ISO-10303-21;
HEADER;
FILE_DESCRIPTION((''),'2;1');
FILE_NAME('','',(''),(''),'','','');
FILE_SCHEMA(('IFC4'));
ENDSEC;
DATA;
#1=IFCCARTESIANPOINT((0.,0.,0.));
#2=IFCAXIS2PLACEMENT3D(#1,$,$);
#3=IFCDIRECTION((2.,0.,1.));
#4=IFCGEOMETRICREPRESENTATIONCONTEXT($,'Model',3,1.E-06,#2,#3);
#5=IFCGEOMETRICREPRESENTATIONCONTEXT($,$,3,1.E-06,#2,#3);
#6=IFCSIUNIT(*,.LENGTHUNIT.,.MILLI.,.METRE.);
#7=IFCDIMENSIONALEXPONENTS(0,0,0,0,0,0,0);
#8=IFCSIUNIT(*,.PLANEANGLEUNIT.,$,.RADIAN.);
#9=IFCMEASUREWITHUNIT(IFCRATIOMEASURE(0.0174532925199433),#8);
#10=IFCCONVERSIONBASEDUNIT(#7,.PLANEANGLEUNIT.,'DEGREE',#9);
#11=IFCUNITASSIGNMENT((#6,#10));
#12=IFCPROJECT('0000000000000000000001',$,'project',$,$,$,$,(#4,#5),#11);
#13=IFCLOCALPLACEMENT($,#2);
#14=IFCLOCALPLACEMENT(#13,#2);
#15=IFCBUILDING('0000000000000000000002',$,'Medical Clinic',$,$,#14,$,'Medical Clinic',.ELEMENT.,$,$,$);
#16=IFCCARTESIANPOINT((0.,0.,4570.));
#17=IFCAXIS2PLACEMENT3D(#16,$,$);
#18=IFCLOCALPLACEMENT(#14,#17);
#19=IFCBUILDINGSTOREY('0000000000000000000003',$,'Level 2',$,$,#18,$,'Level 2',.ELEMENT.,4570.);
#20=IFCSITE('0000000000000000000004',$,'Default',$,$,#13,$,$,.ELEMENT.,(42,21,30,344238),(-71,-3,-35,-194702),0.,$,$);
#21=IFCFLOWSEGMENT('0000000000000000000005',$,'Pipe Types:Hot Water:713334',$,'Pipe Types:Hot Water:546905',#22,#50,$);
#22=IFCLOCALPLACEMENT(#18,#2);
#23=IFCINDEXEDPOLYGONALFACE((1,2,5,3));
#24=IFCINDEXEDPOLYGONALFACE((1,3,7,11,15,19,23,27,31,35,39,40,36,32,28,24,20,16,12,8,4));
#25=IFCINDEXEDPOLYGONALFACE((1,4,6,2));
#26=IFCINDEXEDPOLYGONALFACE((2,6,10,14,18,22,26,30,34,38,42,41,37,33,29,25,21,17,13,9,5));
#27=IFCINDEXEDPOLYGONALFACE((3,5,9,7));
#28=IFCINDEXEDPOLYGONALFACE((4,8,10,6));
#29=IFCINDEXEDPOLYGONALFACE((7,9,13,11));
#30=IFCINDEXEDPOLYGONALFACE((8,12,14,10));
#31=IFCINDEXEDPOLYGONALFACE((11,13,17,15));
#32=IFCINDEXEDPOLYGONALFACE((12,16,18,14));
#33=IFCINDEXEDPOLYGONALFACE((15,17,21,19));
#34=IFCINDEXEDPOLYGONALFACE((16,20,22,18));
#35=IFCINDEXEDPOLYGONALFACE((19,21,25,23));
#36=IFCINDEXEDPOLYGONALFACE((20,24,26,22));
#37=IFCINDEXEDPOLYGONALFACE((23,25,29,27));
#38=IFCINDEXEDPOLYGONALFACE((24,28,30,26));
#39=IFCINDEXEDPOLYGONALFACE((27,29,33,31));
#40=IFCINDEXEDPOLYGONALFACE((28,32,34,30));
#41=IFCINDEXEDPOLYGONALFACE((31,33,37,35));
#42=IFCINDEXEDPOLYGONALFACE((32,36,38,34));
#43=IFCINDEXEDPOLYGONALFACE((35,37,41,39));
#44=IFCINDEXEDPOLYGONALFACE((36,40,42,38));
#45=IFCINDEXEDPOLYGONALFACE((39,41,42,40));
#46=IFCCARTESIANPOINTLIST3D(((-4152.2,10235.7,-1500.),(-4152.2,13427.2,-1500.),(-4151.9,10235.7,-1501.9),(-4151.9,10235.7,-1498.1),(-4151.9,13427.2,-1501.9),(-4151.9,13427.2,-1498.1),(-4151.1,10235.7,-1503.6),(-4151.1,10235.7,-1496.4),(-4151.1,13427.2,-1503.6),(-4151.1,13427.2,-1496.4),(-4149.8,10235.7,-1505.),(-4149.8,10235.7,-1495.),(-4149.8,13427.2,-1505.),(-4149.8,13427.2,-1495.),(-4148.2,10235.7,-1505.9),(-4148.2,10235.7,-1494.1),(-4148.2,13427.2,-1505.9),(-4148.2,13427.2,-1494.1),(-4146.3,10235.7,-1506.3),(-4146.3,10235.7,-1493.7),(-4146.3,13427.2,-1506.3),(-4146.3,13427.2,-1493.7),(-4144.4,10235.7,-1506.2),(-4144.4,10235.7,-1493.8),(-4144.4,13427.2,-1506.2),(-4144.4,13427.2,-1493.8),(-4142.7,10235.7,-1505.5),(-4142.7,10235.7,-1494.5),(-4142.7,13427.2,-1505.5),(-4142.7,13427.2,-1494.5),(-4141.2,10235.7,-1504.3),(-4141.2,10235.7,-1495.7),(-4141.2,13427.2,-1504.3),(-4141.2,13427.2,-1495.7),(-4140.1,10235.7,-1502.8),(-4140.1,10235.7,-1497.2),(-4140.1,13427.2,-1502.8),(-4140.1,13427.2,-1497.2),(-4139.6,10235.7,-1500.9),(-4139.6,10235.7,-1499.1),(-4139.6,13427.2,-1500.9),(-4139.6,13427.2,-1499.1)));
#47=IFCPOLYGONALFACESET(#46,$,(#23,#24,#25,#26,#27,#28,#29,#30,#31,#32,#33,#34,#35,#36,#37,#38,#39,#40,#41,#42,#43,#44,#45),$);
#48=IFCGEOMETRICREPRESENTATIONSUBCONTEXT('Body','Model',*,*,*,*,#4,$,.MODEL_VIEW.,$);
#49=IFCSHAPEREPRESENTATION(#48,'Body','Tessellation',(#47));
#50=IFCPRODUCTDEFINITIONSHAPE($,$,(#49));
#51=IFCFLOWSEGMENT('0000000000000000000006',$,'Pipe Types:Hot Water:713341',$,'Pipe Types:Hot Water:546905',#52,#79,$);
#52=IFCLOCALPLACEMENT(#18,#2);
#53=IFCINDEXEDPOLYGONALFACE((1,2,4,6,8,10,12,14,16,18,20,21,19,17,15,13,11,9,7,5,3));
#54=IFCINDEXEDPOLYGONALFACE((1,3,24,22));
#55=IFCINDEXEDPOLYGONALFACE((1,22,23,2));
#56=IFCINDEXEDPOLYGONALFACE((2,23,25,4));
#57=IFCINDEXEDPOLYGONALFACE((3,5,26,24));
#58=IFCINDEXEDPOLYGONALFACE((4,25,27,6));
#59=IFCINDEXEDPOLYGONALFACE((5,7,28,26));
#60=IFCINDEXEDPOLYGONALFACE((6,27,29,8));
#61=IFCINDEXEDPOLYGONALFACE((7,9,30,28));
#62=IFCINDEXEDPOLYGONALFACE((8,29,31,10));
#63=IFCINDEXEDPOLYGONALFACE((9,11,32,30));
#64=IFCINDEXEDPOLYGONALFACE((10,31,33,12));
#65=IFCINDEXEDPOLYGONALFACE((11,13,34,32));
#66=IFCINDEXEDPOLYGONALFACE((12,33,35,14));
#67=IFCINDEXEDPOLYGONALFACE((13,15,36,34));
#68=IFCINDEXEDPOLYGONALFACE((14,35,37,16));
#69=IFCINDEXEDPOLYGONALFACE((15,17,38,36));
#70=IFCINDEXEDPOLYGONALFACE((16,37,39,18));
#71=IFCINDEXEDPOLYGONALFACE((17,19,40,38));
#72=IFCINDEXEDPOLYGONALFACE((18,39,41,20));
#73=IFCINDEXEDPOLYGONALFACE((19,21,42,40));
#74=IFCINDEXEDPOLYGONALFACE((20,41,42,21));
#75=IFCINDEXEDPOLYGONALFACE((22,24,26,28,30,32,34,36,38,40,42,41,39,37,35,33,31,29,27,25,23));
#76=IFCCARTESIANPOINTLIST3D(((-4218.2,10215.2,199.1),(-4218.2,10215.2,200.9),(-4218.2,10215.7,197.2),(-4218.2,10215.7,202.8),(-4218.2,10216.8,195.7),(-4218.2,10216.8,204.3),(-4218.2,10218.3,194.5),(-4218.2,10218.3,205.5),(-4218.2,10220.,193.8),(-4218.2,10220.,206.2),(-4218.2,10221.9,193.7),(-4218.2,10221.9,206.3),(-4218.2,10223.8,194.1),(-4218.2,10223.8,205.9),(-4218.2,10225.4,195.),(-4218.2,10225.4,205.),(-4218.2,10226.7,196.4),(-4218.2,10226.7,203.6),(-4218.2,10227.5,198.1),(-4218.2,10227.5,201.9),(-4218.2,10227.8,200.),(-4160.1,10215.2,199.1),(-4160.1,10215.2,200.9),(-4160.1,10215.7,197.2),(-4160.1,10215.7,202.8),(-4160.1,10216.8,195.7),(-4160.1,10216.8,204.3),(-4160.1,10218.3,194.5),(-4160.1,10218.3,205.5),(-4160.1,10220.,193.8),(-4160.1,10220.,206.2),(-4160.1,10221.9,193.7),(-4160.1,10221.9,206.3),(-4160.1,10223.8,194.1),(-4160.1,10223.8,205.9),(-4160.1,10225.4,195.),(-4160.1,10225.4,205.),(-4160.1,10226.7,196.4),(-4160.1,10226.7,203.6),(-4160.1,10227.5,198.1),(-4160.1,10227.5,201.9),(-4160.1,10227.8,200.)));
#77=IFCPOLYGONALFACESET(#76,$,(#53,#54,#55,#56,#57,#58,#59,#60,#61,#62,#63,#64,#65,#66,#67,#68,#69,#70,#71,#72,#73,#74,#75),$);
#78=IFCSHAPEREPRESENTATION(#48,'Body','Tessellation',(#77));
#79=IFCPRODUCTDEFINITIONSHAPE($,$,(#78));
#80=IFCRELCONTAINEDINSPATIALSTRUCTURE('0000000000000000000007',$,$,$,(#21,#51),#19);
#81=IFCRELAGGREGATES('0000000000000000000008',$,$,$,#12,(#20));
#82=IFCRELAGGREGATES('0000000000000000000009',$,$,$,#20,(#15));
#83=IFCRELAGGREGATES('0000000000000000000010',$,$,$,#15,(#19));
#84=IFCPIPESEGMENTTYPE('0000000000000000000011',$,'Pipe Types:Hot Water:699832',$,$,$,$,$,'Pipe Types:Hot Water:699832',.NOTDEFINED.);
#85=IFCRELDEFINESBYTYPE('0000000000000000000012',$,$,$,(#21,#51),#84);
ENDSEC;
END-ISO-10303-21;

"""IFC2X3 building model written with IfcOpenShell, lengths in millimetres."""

from ifc_helpers import new_model, entity, si_unit, converted_unit, direction, frame, frame_2d, origin, origin_2d_with_axis, place, context, subcontext, project, spatial, circle, extrude, type_object, element, save


model = new_model("IFC2X3")

# Units and contexts
model_context = context("Model", 3, precision=1e-06, world=origin(), true_north=direction((2.0, 0.0, 1.0)))
context_of_model = context(None, 3, precision=1e-06, world=origin(), true_north=direction((2.0, 0.0, 1.0)))
body_context = subcontext(model_context, "Body", "Model", "MODEL_VIEW")
ifc_project = project(units=[si_unit("LENGTHUNIT", "METRE", prefix="MILLI"), converted_unit("PLANEANGLEUNIT", "DEGREE", entity("IfcRatioMeasure", 0.0174532925199433), si_unit("PLANEANGLEUNIT", "RADIAN"), dimensions=[0, 0, 0, 0, 0, 0, 0])], contexts=[model_context, context_of_model])

# Site, building, storey
site_placement = place(None, origin())
site = spatial("IfcSite", under=ifc_project, at=site_placement, Name="Default", CompositionType="ELEMENT", RefLatitude=(42, 21, 30, 344238), RefLongitude=(-71, -3, -35, -194702), RefElevation=0.0)
building_placement = place(site_placement, origin())
building = spatial("IfcBuilding", under=site, at=building_placement, Name="Medical Clinic", LongName="Medical Clinic", CompositionType="ELEMENT")
storey_placement = place(building_placement, frame((0.0, 0.0, 4570.0)))
storey = spatial("IfcBuildingStorey", under=building, at=storey_placement, Name="Level 2", LongName="Level 2", CompositionType="ELEMENT", Elevation=4570.0)

# Flow segments
pipe_segment_type_1 = type_object("IfcPipeSegmentType", Name="Pipe Types:Hot Water:699832", ElementType="Pipe Types:Hot Water:699832", PredefinedType="NOTDEFINED")
flow_segment_1_placement = place(storey_placement, origin())
element("IfcFlowSegment", 1, at=flow_segment_1_placement, inside=storey, type_object=pipe_segment_type_1, Name="Pipe Types:Hot Water:713334", ObjectType="Pipe Types:Hot Water:546905", context=body_context, shape_type="SweptSolid", body=[
    extrude(circle(Radius=6.3, at=origin_2d_with_axis()), frame((-4145.8, 10235.7, -1500.0), z_axis=(0.0, 1.0, 0.0), x_axis=(-1.0, 0.0, 0.0)), (0.0, 0.0, 1.0), 3191.4),
])
flow_segment_2_placement = place(storey_placement, origin())
element("IfcFlowSegment", 2, at=flow_segment_2_placement, inside=storey, type_object=pipe_segment_type_1, Name="Pipe Types:Hot Water:713341", ObjectType="Pipe Types:Hot Water:546905", context=body_context, shape_type="SweptSolid", body=[
    extrude(circle(Radius=6.3, at=frame_2d((0.0, 0.0), x_axis=(1.0, 0.0))), frame((-4218.2, 10221.5, 200.0), z_axis=(1.0, 0.0, 0.0), x_axis=(0.0, 1.0, 0.0)), (0.0, 0.0, 1.0), 58.0),
])

save(model, "model.ifc")
